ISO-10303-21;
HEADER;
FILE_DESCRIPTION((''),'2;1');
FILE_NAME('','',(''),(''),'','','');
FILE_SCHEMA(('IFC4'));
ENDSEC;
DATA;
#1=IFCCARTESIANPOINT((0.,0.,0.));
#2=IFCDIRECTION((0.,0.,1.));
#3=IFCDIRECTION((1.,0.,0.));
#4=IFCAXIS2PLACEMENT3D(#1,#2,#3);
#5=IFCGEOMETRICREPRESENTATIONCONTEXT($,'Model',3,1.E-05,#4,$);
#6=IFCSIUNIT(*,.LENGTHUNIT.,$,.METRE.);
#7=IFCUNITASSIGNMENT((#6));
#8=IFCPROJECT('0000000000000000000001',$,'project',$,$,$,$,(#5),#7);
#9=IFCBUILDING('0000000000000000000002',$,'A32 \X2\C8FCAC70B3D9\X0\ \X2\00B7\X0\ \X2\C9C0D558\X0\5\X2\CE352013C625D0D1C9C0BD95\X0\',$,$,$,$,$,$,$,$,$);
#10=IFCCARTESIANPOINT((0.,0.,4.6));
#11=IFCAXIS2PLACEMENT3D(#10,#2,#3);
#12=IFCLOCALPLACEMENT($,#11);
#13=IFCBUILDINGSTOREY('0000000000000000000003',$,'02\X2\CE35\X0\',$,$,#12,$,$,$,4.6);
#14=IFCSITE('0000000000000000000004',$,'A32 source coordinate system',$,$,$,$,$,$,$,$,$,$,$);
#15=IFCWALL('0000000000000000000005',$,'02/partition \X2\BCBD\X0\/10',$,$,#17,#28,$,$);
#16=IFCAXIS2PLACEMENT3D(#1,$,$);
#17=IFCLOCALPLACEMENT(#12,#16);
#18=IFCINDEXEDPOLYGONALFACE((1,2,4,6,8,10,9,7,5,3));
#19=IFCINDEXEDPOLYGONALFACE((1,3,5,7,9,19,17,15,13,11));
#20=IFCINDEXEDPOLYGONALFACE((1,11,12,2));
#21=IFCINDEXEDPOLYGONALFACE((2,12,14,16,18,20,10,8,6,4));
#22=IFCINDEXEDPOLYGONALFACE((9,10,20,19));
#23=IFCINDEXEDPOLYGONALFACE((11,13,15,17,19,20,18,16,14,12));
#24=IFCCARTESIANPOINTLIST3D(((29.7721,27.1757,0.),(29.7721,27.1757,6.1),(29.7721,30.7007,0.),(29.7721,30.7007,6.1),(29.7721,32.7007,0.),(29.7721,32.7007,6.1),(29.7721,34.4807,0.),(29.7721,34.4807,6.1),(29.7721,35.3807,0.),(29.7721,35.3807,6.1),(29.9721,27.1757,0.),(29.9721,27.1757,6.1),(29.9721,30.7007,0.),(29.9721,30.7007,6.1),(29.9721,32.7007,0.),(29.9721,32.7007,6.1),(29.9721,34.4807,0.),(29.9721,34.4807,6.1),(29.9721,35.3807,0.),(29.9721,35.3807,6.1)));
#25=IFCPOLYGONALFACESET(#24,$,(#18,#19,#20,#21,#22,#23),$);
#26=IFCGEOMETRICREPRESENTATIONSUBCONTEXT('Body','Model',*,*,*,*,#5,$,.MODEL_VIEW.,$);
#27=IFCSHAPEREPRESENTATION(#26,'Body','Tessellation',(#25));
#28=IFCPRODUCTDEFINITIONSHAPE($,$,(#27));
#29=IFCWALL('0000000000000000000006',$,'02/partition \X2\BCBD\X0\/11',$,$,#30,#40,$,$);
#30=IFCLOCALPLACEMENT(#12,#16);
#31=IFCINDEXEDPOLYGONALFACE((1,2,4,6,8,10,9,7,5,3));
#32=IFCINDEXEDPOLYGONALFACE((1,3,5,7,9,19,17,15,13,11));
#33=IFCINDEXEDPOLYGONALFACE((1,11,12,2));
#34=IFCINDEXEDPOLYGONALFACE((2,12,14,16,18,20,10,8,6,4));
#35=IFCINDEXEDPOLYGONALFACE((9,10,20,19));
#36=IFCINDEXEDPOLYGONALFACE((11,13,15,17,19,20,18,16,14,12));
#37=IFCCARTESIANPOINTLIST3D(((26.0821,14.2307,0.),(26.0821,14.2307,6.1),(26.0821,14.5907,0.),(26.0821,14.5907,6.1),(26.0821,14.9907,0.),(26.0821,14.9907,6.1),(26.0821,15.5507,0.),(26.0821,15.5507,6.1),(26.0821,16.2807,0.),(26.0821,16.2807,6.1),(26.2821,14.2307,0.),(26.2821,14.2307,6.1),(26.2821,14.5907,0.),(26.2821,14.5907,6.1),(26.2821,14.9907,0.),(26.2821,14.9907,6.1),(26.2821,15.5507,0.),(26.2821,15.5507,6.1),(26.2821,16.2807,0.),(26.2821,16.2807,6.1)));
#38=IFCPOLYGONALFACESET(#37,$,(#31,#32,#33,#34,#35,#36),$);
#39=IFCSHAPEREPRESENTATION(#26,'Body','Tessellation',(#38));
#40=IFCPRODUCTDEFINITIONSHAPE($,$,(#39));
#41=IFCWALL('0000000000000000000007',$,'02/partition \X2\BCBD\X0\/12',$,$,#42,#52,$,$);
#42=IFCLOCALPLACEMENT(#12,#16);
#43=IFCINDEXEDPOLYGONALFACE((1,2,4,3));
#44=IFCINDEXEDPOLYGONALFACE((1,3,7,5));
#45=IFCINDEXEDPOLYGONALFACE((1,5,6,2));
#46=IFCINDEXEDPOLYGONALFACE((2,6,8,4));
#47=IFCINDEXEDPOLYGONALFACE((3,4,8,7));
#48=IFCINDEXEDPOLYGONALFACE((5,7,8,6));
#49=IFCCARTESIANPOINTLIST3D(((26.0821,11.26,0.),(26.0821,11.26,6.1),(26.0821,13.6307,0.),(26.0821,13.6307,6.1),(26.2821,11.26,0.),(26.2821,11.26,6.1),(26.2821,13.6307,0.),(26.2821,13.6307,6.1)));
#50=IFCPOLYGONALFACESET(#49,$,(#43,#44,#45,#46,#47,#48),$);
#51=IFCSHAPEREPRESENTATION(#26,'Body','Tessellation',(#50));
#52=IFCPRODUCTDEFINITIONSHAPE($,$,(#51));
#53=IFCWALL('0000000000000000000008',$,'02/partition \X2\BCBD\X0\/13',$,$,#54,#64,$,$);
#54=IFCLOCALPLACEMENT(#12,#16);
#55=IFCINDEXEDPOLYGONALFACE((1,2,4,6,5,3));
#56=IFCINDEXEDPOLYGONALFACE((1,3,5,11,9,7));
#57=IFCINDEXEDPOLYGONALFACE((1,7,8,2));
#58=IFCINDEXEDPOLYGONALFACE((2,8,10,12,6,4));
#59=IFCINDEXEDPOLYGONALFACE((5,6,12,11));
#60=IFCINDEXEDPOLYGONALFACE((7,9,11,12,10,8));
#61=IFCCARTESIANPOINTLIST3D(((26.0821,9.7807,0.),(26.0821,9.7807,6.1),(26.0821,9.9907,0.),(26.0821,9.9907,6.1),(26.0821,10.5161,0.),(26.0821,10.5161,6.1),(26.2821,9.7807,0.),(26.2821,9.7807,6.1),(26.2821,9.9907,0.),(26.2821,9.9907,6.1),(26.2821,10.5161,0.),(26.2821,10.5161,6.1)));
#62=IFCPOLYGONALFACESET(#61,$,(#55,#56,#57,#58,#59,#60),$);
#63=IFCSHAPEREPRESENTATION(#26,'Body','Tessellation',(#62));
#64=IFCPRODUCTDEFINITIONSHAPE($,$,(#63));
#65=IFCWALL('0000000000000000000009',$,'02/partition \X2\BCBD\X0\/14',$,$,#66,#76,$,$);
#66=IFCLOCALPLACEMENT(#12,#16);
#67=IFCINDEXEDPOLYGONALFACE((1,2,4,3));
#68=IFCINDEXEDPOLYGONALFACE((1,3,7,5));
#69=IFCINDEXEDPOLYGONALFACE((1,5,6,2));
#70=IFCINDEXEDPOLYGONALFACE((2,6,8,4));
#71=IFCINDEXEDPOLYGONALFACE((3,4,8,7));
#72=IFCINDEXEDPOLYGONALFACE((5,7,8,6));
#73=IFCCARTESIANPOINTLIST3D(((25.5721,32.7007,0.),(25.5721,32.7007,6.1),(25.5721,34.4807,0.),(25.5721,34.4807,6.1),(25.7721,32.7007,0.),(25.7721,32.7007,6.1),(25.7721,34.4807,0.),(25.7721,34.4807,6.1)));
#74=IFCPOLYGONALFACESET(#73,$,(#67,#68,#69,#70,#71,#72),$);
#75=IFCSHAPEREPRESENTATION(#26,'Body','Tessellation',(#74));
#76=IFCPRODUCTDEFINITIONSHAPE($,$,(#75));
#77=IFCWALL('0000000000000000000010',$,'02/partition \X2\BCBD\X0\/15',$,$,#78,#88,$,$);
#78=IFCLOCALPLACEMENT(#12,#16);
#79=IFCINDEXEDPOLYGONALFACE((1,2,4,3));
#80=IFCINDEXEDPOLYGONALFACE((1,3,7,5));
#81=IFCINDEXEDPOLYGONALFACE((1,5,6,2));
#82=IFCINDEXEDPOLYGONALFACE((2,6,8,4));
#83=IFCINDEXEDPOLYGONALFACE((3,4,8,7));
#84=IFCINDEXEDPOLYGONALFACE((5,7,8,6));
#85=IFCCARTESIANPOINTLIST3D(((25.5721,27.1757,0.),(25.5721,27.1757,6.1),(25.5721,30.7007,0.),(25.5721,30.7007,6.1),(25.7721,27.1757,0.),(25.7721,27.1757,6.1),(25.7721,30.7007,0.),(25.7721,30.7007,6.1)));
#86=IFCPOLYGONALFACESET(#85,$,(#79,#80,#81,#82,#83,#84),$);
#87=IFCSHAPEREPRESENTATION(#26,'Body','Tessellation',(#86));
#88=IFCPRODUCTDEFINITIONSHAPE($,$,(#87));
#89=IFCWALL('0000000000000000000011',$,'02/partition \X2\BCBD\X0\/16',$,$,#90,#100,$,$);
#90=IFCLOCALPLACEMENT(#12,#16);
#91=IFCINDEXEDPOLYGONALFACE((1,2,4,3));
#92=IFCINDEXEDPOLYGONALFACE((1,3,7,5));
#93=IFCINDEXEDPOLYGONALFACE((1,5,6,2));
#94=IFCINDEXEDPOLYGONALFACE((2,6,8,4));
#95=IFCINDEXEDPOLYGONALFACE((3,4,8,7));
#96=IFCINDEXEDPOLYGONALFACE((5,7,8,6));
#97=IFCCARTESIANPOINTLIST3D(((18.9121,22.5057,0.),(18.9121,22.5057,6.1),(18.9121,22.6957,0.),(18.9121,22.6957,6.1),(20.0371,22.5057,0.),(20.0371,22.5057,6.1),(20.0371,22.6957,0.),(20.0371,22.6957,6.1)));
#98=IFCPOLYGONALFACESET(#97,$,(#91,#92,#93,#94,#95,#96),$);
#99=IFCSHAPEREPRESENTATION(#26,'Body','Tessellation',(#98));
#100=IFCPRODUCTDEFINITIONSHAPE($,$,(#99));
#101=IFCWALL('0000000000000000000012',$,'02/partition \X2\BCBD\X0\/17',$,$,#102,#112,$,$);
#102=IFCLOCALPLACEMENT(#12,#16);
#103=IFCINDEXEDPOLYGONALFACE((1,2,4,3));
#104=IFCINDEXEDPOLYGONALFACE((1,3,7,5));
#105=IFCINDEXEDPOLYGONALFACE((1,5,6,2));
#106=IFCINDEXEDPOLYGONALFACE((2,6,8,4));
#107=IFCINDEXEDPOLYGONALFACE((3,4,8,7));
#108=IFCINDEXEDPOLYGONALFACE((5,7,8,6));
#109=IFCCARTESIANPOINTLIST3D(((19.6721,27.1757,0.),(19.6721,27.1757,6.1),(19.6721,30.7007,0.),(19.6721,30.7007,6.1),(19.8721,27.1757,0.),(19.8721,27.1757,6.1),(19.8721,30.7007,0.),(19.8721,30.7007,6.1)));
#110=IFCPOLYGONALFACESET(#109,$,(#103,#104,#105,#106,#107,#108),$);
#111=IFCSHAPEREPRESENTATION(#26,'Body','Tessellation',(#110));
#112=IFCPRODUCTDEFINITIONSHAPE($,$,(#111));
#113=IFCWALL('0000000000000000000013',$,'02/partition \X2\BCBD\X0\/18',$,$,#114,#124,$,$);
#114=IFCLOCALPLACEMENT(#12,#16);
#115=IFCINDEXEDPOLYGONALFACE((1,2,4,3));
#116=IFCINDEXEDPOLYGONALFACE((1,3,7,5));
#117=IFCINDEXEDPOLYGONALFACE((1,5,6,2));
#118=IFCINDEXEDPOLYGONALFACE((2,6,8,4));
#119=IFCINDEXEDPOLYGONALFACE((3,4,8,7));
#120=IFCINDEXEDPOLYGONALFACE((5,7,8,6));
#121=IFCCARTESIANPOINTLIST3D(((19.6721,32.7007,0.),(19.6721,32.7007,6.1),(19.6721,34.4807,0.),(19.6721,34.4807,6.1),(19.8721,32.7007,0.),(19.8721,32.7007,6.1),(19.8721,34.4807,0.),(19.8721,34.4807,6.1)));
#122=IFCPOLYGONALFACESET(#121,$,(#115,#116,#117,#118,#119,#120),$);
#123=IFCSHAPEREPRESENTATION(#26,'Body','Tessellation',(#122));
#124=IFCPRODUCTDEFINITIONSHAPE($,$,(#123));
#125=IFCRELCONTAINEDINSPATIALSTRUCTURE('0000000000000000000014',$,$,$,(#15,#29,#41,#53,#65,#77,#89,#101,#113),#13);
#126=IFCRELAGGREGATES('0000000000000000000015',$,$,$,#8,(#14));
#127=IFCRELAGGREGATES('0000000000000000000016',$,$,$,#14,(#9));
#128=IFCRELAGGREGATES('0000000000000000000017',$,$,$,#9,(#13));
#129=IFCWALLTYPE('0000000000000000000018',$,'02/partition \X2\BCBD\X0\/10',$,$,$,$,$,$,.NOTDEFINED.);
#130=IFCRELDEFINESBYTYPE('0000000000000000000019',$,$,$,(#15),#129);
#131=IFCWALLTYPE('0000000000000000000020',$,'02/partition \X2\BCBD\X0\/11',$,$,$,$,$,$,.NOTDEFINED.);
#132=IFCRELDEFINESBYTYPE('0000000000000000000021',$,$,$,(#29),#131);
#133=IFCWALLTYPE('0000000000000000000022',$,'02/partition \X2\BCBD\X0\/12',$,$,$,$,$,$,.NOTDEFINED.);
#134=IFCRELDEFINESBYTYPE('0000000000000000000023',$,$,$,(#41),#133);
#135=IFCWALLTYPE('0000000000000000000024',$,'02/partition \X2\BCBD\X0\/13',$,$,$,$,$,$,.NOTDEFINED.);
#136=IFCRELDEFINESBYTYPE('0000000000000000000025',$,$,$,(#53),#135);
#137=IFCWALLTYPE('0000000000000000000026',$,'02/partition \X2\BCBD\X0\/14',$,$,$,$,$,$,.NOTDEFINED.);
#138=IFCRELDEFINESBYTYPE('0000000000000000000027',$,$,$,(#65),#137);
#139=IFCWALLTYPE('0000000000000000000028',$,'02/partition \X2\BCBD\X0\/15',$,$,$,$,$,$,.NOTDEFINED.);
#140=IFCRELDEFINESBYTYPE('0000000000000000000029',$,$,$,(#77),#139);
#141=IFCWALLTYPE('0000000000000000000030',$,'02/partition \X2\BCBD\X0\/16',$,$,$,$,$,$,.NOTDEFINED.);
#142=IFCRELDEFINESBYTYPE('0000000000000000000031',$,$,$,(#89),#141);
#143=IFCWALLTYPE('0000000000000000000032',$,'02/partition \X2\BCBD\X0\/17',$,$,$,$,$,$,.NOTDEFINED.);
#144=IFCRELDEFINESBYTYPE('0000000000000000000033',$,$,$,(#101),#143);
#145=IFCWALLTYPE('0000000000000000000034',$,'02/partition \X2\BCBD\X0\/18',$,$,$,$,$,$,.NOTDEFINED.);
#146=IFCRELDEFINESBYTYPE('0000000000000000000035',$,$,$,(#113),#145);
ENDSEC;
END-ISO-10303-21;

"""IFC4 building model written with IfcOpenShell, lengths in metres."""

from ifc_helpers import new_model, si_unit, frame, origin, origin_with_axes, place, context, subcontext, project, spatial, polyline, outline, extrude, source, transform, mapped, type_object, type_shapes, element, save


model = new_model("IFC4")

# Units and contexts
model_context = context("Model", 3, precision=1e-05, world=origin_with_axes())
body_context = subcontext(model_context, "Body", "Model", "MODEL_VIEW")
ifc_project = project(units=[si_unit("LENGTHUNIT", "METRE")], contexts=[model_context])

# Site, building, storey
site = spatial("IfcSite", under=ifc_project, Name="A32 source coordinate system")
building = spatial("IfcBuilding", under=site, Name="A32 주거동 · 지하5층–옥탑지붕")
storey_placement = place(None, frame((0.0, 0.0, 4.6), z_axis=(0.0, 0.0, 1.0), x_axis=(1.0, 0.0, 0.0)))
storey = spatial("IfcBuildingStorey", under=building, at=storey_placement, Name="02층", Elevation=4.6)

# Walls
wall_type_1 = type_object("IfcWallType", Name="02/partition 벽/10", PredefinedType="NOTDEFINED")
shared_shape_1 = source(origin(), body_context, "Body", "SweptSolid", [
    extrude(outline(polyline([(29.7721, 34.4807), (29.7721, 35.3807), (29.9721, 35.3807), (29.9721, 34.4807), (29.9721, 32.7007), (29.9721, 30.7007), (29.9721, 27.1757), (29.7721, 27.1757), (29.7721, 30.7007), (29.7721, 32.7007), (29.7721, 34.4807)])), origin(), (0.0, 0.0, 1.0), 6.1),
])
type_shapes(wall_type_1, [shared_shape_1])
wall_1_placement = place(storey_placement, origin_with_axes())
element("IfcWall", 1, at=wall_1_placement, inside=storey, type_object=wall_type_1, Name="02/partition 벽/10", context=body_context, shape_type="MappedRepresentation", body=[
    mapped(shared_shape_1, transform((0.0, 0.0, 0.0), scale=1.0)),
])
wall_type_2 = type_object("IfcWallType", Name="02/partition 벽/11", PredefinedType="NOTDEFINED")
shared_shape_2 = source(origin(), body_context, "Body", "SweptSolid", [
    extrude(outline(polyline([(26.2821, 16.2807), (26.2821, 15.5507), (26.2821, 14.9907), (26.2821, 14.5907), (26.2821, 14.2307), (26.0821, 14.2307), (26.0821, 14.5907), (26.0821, 14.9907), (26.0821, 15.5507), (26.0821, 16.2807), (26.2821, 16.2807)])), origin(), (0.0, 0.0, 1.0), 6.1),
])
type_shapes(wall_type_2, [shared_shape_2])
wall_2_placement = place(storey_placement, origin_with_axes())
element("IfcWall", 2, at=wall_2_placement, inside=storey, type_object=wall_type_2, Name="02/partition 벽/11", context=body_context, shape_type="MappedRepresentation", body=[
    mapped(shared_shape_2, transform((0.0, 0.0, 0.0), scale=1.0)),
])
wall_type_3 = type_object("IfcWallType", Name="02/partition 벽/12", PredefinedType="NOTDEFINED")
shared_shape_3 = source(origin(), body_context, "Body", "SweptSolid", [
    extrude(outline(polyline([(26.0821, 13.6307), (26.2821, 13.6307), (26.2821, 11.26), (26.0821, 11.26), (26.0821, 13.6307)])), origin(), (0.0, 0.0, 1.0), 6.1),
])
type_shapes(wall_type_3, [shared_shape_3])
wall_3_placement = place(storey_placement, origin_with_axes())
element("IfcWall", 3, at=wall_3_placement, inside=storey, type_object=wall_type_3, Name="02/partition 벽/12", context=body_context, shape_type="MappedRepresentation", body=[
    mapped(shared_shape_3, transform((0.0, 0.0, 0.0), scale=1.0)),
])
wall_type_4 = type_object("IfcWallType", Name="02/partition 벽/13", PredefinedType="NOTDEFINED")
shared_shape_4 = source(origin(), body_context, "Body", "SweptSolid", [
    extrude(outline(polyline([(26.2821, 10.5161), (26.2821, 9.9907), (26.2821, 9.7807), (26.0821, 9.7807), (26.0821, 9.9907), (26.0821, 10.5161), (26.2821, 10.5161)])), origin(), (0.0, 0.0, 1.0), 6.1),
])
type_shapes(wall_type_4, [shared_shape_4])
wall_4_placement = place(storey_placement, origin_with_axes())
element("IfcWall", 4, at=wall_4_placement, inside=storey, type_object=wall_type_4, Name="02/partition 벽/13", context=body_context, shape_type="MappedRepresentation", body=[
    mapped(shared_shape_4, transform((0.0, 0.0, 0.0), scale=1.0)),
])
wall_type_5 = type_object("IfcWallType", Name="02/partition 벽/14", PredefinedType="NOTDEFINED")
shared_shape_5 = source(origin(), body_context, "Body", "SweptSolid", [
    extrude(outline(polyline([(25.7721, 34.4807), (25.7721, 32.7007), (25.5721, 32.7007), (25.5721, 34.4807), (25.7721, 34.4807)])), origin(), (0.0, 0.0, 1.0), 6.1),
])
type_shapes(wall_type_5, [shared_shape_5])
wall_5_placement = place(storey_placement, origin_with_axes())
element("IfcWall", 5, at=wall_5_placement, inside=storey, type_object=wall_type_5, Name="02/partition 벽/14", context=body_context, shape_type="MappedRepresentation", body=[
    mapped(shared_shape_5, transform((0.0, 0.0, 0.0), scale=1.0)),
])
wall_type_6 = type_object("IfcWallType", Name="02/partition 벽/15", PredefinedType="NOTDEFINED")
shared_shape_6 = source(origin(), body_context, "Body", "SweptSolid", [
    extrude(outline(polyline([(25.7721, 30.7007), (25.7721, 27.1757), (25.5721, 27.1757), (25.5721, 30.7007), (25.7721, 30.7007)])), origin(), (0.0, 0.0, 1.0), 6.1),
])
type_shapes(wall_type_6, [shared_shape_6])
wall_6_placement = place(storey_placement, origin_with_axes())
element("IfcWall", 6, at=wall_6_placement, inside=storey, type_object=wall_type_6, Name="02/partition 벽/15", context=body_context, shape_type="MappedRepresentation", body=[
    mapped(shared_shape_6, transform((0.0, 0.0, 0.0), scale=1.0)),
])
wall_type_7 = type_object("IfcWallType", Name="02/partition 벽/16", PredefinedType="NOTDEFINED")
shared_shape_7 = source(origin(), body_context, "Body", "SweptSolid", [
    extrude(outline(polyline([(20.0371, 22.6957), (20.0371, 22.5057), (18.9121, 22.5057), (18.9121, 22.6957), (20.0371, 22.6957)])), origin(), (0.0, 0.0, 1.0), 6.1),
])
type_shapes(wall_type_7, [shared_shape_7])
wall_7_placement = place(storey_placement, origin_with_axes())
element("IfcWall", 7, at=wall_7_placement, inside=storey, type_object=wall_type_7, Name="02/partition 벽/16", context=body_context, shape_type="MappedRepresentation", body=[
    mapped(shared_shape_7, transform((0.0, 0.0, 0.0), scale=1.0)),
])
wall_type_8 = type_object("IfcWallType", Name="02/partition 벽/17", PredefinedType="NOTDEFINED")
shared_shape_8 = source(origin(), body_context, "Body", "SweptSolid", [
    extrude(outline(polyline([(19.8721, 30.7007), (19.8721, 27.1757), (19.6721, 27.1757), (19.6721, 30.7007), (19.8721, 30.7007)])), origin(), (0.0, 0.0, 1.0), 6.1),
])
type_shapes(wall_type_8, [shared_shape_8])
wall_8_placement = place(storey_placement, origin_with_axes())
element("IfcWall", 8, at=wall_8_placement, inside=storey, type_object=wall_type_8, Name="02/partition 벽/17", context=body_context, shape_type="MappedRepresentation", body=[
    mapped(shared_shape_8, transform((0.0, 0.0, 0.0), scale=1.0)),
])
wall_type_9 = type_object("IfcWallType", Name="02/partition 벽/18", PredefinedType="NOTDEFINED")
shared_shape_9 = source(origin(), body_context, "Body", "SweptSolid", [
    extrude(outline(polyline([(19.6721, 34.4807), (19.8721, 34.4807), (19.8721, 32.7007), (19.6721, 32.7007), (19.6721, 34.4807)])), origin(), (0.0, 0.0, 1.0), 6.1),
])
type_shapes(wall_type_9, [shared_shape_9])
wall_9_placement = place(storey_placement, origin_with_axes())
element("IfcWall", 9, at=wall_9_placement, inside=storey, type_object=wall_type_9, Name="02/partition 벽/18", context=body_context, shape_type="MappedRepresentation", body=[
    mapped(shared_shape_9, transform((0.0, 0.0, 0.0), scale=1.0)),
])

save(model, "model.ifc")
